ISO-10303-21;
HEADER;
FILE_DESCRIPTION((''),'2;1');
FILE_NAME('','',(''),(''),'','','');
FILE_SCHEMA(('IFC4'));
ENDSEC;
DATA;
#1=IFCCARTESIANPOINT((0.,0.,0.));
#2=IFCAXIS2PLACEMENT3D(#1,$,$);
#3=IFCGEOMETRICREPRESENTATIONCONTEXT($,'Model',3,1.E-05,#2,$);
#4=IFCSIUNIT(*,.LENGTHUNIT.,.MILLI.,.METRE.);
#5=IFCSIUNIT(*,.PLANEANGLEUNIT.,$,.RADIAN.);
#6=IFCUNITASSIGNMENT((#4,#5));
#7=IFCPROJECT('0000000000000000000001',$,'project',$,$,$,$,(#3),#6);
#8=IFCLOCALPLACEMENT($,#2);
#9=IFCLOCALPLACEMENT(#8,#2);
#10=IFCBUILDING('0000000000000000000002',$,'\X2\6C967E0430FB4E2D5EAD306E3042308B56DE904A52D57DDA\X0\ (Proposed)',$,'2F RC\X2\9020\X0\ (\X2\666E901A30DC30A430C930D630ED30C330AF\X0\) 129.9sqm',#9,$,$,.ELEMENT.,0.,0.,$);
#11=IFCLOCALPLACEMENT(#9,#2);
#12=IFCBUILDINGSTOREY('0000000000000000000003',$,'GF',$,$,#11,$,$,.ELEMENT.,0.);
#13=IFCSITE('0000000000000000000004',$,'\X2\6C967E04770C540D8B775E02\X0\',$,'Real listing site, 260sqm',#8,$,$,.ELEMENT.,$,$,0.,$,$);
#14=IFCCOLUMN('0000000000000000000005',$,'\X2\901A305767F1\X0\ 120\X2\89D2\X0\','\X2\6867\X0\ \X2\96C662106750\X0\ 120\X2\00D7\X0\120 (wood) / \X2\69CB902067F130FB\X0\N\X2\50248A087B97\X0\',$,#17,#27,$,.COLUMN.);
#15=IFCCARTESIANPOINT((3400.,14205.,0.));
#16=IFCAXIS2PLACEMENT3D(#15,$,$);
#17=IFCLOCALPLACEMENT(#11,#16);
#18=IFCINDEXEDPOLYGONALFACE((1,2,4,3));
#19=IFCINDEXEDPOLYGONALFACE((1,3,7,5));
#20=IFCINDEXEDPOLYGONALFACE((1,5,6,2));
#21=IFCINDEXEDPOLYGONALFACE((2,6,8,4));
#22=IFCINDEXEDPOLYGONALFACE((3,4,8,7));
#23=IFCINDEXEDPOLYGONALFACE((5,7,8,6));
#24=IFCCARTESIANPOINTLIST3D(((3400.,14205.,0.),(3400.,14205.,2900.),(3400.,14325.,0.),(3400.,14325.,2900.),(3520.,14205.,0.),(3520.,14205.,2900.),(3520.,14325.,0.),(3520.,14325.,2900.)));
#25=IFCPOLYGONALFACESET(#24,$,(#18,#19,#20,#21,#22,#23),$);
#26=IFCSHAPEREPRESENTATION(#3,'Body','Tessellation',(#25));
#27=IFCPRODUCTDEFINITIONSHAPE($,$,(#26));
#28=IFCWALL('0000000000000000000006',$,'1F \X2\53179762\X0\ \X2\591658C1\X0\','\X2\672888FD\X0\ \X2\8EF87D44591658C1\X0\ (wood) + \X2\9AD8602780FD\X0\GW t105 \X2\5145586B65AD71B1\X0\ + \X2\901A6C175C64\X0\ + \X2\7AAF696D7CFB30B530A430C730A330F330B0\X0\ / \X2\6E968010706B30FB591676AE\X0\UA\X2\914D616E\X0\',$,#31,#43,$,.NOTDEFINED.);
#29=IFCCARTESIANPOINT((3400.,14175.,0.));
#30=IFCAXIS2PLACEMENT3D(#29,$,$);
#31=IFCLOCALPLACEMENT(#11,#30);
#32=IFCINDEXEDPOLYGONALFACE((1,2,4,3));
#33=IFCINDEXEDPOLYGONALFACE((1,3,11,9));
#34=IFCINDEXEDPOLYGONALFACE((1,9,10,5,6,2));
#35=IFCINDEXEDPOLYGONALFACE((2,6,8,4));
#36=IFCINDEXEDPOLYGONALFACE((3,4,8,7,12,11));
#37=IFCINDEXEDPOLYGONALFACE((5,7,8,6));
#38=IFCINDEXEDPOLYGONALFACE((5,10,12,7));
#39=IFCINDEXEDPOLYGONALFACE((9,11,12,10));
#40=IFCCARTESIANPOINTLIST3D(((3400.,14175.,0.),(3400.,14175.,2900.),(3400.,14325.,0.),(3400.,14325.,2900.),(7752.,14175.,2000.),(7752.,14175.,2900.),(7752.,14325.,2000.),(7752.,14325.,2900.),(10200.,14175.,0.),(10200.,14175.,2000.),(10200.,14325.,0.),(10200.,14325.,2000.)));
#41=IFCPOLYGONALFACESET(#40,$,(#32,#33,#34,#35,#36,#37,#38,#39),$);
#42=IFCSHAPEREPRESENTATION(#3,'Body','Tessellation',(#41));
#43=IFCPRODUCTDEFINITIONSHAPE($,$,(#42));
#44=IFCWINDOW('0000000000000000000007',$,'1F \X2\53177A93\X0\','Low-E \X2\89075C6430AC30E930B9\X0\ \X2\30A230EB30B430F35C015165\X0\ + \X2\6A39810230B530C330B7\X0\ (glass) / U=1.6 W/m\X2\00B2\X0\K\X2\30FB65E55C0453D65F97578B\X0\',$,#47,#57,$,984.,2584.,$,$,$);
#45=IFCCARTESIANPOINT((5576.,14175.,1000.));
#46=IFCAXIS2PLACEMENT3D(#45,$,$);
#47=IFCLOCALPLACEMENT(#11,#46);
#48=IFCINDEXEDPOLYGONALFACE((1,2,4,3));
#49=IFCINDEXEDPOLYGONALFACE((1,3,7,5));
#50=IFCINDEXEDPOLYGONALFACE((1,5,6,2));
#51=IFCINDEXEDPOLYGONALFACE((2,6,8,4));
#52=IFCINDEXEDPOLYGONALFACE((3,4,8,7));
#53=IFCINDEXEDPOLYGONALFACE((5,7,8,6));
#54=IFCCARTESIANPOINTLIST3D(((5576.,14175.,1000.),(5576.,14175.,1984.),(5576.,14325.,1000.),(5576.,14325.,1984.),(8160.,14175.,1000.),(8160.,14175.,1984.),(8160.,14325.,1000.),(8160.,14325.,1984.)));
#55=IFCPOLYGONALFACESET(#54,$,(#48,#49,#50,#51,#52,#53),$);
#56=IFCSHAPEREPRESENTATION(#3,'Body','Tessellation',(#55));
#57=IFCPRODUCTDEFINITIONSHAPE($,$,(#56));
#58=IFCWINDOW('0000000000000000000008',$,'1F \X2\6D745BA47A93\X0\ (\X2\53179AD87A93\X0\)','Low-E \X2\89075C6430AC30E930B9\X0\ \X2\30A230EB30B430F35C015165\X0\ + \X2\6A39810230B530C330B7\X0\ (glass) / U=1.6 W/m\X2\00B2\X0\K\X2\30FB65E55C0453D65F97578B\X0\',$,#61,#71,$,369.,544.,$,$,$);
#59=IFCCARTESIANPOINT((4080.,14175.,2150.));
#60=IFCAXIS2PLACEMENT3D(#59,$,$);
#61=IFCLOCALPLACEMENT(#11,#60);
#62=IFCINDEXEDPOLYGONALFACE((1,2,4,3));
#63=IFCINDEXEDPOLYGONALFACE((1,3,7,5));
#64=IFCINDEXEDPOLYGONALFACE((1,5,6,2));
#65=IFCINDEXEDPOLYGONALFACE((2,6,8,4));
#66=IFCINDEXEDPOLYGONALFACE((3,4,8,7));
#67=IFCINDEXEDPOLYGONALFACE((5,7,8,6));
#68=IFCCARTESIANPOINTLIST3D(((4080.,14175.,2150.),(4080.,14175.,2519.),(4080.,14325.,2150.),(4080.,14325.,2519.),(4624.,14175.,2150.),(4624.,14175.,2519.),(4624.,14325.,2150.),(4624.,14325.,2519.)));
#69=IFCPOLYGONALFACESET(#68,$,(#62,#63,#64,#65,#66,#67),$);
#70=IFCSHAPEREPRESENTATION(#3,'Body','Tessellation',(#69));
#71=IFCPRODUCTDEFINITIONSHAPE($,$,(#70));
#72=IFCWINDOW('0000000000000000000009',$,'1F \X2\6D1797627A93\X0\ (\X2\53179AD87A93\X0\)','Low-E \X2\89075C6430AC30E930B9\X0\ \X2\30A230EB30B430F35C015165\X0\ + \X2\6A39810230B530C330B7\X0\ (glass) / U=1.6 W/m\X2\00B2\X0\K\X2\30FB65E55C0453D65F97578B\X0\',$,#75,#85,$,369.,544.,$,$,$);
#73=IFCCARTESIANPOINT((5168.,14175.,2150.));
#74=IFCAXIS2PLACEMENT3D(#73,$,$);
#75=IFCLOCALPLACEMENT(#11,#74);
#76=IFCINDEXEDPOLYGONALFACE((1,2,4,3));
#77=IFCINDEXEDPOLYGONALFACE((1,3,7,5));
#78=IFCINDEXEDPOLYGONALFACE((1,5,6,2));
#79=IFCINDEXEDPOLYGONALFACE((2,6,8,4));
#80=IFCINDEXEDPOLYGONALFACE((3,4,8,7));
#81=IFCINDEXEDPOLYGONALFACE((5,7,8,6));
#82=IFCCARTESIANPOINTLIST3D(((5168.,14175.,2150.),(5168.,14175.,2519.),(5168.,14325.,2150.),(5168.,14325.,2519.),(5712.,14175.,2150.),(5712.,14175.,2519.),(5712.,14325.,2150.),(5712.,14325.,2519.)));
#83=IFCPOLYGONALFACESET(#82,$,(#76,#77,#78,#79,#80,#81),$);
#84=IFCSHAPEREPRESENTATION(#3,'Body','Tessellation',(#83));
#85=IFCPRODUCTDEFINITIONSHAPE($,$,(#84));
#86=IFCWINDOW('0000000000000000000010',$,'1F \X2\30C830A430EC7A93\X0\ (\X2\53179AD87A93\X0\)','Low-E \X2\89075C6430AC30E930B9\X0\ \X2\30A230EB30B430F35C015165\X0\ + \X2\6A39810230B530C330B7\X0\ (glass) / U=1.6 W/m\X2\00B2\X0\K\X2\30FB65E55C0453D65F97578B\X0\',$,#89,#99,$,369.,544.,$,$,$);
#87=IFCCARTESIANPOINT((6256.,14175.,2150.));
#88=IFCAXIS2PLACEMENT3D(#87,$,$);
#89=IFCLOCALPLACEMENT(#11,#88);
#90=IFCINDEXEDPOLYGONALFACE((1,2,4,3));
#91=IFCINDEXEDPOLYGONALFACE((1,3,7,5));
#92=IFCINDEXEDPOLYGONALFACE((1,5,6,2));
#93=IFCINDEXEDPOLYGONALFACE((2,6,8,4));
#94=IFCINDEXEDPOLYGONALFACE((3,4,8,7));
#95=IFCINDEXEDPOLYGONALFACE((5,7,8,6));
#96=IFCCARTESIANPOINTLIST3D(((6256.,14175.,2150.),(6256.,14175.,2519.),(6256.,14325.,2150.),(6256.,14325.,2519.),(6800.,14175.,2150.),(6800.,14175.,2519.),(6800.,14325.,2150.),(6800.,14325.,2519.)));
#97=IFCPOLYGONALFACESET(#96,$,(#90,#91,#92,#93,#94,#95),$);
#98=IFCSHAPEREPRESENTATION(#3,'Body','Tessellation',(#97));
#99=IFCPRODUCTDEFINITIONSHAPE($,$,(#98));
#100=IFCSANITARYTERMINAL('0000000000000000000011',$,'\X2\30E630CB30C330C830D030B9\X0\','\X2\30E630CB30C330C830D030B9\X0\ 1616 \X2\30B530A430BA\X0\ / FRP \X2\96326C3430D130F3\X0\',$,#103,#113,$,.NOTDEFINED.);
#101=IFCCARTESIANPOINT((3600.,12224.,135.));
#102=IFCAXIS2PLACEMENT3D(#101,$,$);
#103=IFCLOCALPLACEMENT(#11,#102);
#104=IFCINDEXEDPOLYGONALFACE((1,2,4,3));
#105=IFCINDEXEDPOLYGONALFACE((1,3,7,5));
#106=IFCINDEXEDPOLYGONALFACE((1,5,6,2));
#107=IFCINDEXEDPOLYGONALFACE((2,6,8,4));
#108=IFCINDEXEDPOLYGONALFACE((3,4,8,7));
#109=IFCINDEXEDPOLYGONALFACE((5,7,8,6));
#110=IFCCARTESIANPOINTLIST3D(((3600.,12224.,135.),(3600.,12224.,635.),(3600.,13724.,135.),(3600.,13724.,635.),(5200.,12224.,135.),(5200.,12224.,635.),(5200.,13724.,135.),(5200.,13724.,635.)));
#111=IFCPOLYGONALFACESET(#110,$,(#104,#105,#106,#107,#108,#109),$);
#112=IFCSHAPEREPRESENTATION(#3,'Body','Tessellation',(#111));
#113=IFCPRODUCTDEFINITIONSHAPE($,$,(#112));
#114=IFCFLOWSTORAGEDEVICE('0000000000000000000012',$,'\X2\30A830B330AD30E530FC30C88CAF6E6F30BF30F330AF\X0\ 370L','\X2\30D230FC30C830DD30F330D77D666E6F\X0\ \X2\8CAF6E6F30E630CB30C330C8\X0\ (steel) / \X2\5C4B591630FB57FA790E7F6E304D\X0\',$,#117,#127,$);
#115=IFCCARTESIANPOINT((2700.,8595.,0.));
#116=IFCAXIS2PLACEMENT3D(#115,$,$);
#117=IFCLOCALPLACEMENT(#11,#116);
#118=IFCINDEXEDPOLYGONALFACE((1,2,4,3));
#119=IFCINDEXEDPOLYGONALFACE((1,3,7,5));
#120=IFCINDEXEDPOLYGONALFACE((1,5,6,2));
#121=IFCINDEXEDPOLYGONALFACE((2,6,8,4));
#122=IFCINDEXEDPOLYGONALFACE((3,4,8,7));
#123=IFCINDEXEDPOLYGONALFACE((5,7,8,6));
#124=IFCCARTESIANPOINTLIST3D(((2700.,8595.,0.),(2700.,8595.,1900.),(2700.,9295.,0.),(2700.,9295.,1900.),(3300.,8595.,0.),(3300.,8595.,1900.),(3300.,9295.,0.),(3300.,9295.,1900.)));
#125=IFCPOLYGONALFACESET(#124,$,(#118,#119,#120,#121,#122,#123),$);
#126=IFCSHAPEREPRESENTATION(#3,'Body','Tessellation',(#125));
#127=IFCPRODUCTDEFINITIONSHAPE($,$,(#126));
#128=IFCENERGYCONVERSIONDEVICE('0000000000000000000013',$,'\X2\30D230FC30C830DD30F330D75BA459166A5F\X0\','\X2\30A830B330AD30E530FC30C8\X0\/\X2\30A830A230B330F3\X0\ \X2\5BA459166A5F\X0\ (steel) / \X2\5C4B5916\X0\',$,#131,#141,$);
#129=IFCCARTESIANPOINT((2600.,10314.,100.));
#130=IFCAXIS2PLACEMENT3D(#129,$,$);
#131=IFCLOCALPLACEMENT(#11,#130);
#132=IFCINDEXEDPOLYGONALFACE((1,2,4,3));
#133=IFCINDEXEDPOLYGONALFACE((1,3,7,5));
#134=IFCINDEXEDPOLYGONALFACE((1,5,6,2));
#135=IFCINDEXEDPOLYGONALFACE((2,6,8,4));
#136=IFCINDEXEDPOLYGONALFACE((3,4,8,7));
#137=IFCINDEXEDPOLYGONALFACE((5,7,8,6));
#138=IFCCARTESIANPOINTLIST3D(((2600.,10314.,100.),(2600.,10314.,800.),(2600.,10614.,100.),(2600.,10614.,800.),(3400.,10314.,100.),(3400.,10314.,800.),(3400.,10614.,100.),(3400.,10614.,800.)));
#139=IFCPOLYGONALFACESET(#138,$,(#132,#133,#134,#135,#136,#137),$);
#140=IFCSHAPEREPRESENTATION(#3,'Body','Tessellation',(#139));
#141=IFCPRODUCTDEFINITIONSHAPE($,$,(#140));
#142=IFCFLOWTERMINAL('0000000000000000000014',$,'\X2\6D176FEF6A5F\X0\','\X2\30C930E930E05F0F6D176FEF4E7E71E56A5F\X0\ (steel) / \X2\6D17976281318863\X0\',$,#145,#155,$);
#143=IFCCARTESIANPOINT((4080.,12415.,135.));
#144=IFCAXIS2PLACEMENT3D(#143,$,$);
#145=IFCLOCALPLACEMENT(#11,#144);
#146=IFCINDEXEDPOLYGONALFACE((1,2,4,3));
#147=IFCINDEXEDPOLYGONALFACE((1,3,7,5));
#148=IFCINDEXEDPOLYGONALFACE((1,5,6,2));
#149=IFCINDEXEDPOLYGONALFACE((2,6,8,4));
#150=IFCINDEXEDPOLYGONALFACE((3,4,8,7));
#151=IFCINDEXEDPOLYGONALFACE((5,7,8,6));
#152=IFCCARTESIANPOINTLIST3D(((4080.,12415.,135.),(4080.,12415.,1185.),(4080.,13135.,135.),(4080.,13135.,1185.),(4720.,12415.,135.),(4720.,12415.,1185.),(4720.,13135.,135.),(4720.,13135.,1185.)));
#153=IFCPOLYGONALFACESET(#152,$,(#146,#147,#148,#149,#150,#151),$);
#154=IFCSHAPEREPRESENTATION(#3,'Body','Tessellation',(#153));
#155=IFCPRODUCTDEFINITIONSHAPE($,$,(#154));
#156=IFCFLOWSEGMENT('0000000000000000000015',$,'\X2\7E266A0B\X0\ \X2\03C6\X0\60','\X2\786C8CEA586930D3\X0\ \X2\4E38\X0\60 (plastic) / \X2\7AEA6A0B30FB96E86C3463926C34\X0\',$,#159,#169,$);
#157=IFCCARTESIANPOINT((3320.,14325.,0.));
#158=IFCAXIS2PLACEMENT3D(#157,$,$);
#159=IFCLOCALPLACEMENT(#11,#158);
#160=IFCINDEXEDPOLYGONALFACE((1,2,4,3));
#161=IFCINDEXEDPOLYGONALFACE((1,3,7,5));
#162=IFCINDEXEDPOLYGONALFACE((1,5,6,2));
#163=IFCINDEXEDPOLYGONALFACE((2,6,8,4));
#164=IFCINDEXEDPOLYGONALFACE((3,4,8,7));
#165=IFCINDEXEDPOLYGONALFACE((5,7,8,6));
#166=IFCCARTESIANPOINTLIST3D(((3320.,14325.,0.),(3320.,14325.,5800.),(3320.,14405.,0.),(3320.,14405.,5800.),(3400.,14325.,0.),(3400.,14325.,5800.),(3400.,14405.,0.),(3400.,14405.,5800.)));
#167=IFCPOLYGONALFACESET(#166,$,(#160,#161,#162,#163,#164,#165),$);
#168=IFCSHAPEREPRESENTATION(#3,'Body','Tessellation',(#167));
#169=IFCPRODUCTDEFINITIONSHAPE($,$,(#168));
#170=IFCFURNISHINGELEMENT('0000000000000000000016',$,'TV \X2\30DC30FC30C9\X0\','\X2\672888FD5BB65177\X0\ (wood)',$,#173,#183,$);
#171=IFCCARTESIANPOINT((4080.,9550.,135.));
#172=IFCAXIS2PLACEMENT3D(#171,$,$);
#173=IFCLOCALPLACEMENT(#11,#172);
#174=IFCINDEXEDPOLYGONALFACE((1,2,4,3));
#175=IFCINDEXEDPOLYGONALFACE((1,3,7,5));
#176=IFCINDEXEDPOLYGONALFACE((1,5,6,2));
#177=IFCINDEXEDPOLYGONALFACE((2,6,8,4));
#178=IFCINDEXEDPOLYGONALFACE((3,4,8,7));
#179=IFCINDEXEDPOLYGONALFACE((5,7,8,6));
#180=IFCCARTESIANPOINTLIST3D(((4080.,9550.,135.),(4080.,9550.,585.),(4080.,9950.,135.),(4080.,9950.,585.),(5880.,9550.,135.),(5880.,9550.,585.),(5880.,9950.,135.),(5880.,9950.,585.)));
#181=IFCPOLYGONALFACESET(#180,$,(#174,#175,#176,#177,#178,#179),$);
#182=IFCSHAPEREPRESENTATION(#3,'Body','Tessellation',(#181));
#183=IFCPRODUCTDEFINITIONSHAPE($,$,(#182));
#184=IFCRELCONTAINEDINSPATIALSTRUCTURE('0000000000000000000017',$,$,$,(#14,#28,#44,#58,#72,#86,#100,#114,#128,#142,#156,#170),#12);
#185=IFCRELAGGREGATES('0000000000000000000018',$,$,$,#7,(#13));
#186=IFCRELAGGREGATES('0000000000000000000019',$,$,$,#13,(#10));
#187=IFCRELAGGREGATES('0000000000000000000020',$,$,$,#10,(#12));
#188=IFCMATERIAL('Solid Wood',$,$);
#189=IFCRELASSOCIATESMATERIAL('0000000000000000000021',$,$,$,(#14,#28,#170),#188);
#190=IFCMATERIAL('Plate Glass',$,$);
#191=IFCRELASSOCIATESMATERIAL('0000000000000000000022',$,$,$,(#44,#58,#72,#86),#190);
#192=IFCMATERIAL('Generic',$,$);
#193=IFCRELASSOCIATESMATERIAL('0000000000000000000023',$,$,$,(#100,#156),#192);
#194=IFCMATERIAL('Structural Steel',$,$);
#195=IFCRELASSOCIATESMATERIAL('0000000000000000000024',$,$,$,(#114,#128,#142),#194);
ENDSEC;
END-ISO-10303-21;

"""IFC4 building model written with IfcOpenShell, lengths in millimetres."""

from ifc_helpers import new_model, si_unit, frame, frame_2d, origin, place, context, project, spatial, rectangle, extrude, material, element, fill, save


model = new_model("IFC4")

# Units and contexts
model_context = context("Model", 3, precision=1e-05, world=origin())
ifc_project = project(units=[si_unit("LENGTHUNIT", "METRE", prefix="MILLI"), si_unit("PLANEANGLEUNIT", "RADIAN")], contexts=[model_context])

# Site, building, storey
site_placement = place(None, origin())
site = spatial("IfcSite", under=ifc_project, at=site_placement, Name="沖縄県名護市", ObjectType="Real listing site, 260sqm", CompositionType="ELEMENT", RefElevation=0.0)
building_placement = place(site_placement, origin())
building = spatial("IfcBuilding", under=site, at=building_placement, Name="沖縄・中庭のある回遊動線 (Proposed)", ObjectType="2F RC造 (普通ボイドブロック) 129.9sqm", CompositionType="ELEMENT", ElevationOfRefHeight=0.0, ElevationOfTerrain=0.0)
storey_placement = place(building_placement, origin())
storey = spatial("IfcBuildingStorey", under=building, at=storey_placement, Name="GF", CompositionType="ELEMENT", Elevation=0.0)

# Column
ifc_material_1 = material(Name="Solid Wood")
column_1_placement = place(storey_placement, frame((3400.0, 14205.0, 0.0)))
element("IfcColumn", 1, at=column_1_placement, inside=storey, material=ifc_material_1, Name="通し柱 120角", Description="桧 集成材 120×120 (wood) / 構造柱・N値計算", PredefinedType="COLUMN", context=model_context, shape_type="SweptSolid", body=[
    extrude(rectangle(XDim=120.0, YDim=120.0, at=frame_2d((60.0, 60.0))), frame((3400.0, 14205.0, 0.0)), (0.0, 0.0, 1.0), 2900.0),
])

# Wall, openings, windows
wall_1_placement = place(storey_placement, frame((3400.0, 14175.0, 0.0)))
wall_1 = element("IfcWall", 2, at=wall_1_placement, inside=storey, material=ifc_material_1, Name="1F 北面 外壁", Description="木製 軸組外壁 (wood) + 高性能GW t105 充填断熱 + 通気層 + 窯業系サイディング / 準耐火・外皮UA配慮", PredefinedType="NOTDEFINED", context=model_context, shape_type="SweptSolid", body=[
    extrude(rectangle(XDim=6800.0, YDim=150.0, at=frame_2d((3400.0, 75.0))), frame((3400.0, 14175.0, 0.0)), (0.0, 0.0, 1.0), 2900.0),
])
opening_1_placement = place(storey_placement, frame((5576.0, 14175.0, 1000.0)))
opening_1 = element("IfcOpeningElement", 3, at=opening_1_placement, cuts=wall_1, PredefinedType="NOTDEFINED", context=model_context, shape_type="SweptSolid", body=[
    extrude(rectangle(XDim=2584.0, YDim=150.0, at=frame_2d((1292.0, 75.0))), frame((5576.0, 14175.0, 1000.0)), (0.0, 0.0, 1.0), 984.0),
])
opening_2_placement = place(storey_placement, frame((4080.0, 14175.0, 2150.0)))
opening_2 = element("IfcOpeningElement", 4, at=opening_2_placement, cuts=wall_1, PredefinedType="NOTDEFINED", context=model_context, shape_type="SweptSolid", body=[
    extrude(rectangle(XDim=544.0, YDim=150.0, at=frame_2d((272.0, 75.0))), frame((4080.0, 14175.0, 2150.0)), (0.0, 0.0, 1.0), 369.0),
])
opening_3_placement = place(storey_placement, frame((5168.0, 14175.0, 2150.0)))
opening_3 = element("IfcOpeningElement", 5, at=opening_3_placement, cuts=wall_1, PredefinedType="NOTDEFINED", context=model_context, shape_type="SweptSolid", body=[
    extrude(rectangle(XDim=544.0, YDim=150.0, at=frame_2d((272.0, 75.0))), frame((5168.0, 14175.0, 2150.0)), (0.0, 0.0, 1.0), 369.0),
])
opening_4_placement = place(storey_placement, frame((6256.0, 14175.0, 2150.0)))
opening_4 = element("IfcOpeningElement", 6, at=opening_4_placement, cuts=wall_1, PredefinedType="NOTDEFINED", context=model_context, shape_type="SweptSolid", body=[
    extrude(rectangle(XDim=544.0, YDim=150.0, at=frame_2d((272.0, 75.0))), frame((6256.0, 14175.0, 2150.0)), (0.0, 0.0, 1.0), 369.0),
])
ifc_material_2 = material(Name="Plate Glass")
window_1_placement = place(storey_placement, frame((5576.0, 14175.0, 1000.0)))
window_1 = element("IfcWindow", 7, at=window_1_placement, inside=storey, material=ifc_material_2, Name="1F 北窓", Description="Low-E 複層ガラス アルゴン封入 + 樹脂サッシ (glass) / U=1.6 W/m²K・日射取得型", OverallHeight=984.0, OverallWidth=2584.0, context=model_context, shape_type="SweptSolid", body=[
    extrude(rectangle(XDim=2584.0, YDim=150.0, at=frame_2d((1292.0, 75.0))), frame((5576.0, 14175.0, 1000.0)), (0.0, 0.0, 1.0), 984.0),
])
fill(opening_1, window_1)
window_2_placement = place(storey_placement, frame((4080.0, 14175.0, 2150.0)))
window_2 = element("IfcWindow", 8, at=window_2_placement, inside=storey, material=ifc_material_2, Name="1F 浴室窓 (北高窓)", Description="Low-E 複層ガラス アルゴン封入 + 樹脂サッシ (glass) / U=1.6 W/m²K・日射取得型", OverallHeight=369.0, OverallWidth=544.0, context=model_context, shape_type="SweptSolid", body=[
    extrude(rectangle(XDim=544.0, YDim=150.0, at=frame_2d((272.0, 75.0))), frame((4080.0, 14175.0, 2150.0)), (0.0, 0.0, 1.0), 369.0),
])
fill(opening_2, window_2)
window_3_placement = place(storey_placement, frame((5168.0, 14175.0, 2150.0)))
window_3 = element("IfcWindow", 9, at=window_3_placement, inside=storey, material=ifc_material_2, Name="1F 洗面窓 (北高窓)", Description="Low-E 複層ガラス アルゴン封入 + 樹脂サッシ (glass) / U=1.6 W/m²K・日射取得型", OverallHeight=369.0, OverallWidth=544.0, context=model_context, shape_type="SweptSolid", body=[
    extrude(rectangle(XDim=544.0, YDim=150.0, at=frame_2d((272.0, 75.0))), frame((5168.0, 14175.0, 2150.0)), (0.0, 0.0, 1.0), 369.0),
])
fill(opening_3, window_3)
window_4_placement = place(storey_placement, frame((6256.0, 14175.0, 2150.0)))
window_4 = element("IfcWindow", 10, at=window_4_placement, inside=storey, material=ifc_material_2, Name="1F トイレ窓 (北高窓)", Description="Low-E 複層ガラス アルゴン封入 + 樹脂サッシ (glass) / U=1.6 W/m²K・日射取得型", OverallHeight=369.0, OverallWidth=544.0, context=model_context, shape_type="SweptSolid", body=[
    extrude(rectangle(XDim=544.0, YDim=150.0, at=frame_2d((272.0, 75.0))), frame((6256.0, 14175.0, 2150.0)), (0.0, 0.0, 1.0), 369.0),
])
fill(opening_4, window_4)

# Sanitary terminal
ifc_material_3 = material(Name="Generic")
sanitary_terminal_placement = place(storey_placement, frame((3600.0, 12224.0, 135.0)))
element("IfcSanitaryTerminal", 11, at=sanitary_terminal_placement, inside=storey, material=ifc_material_3, Name="ユニットバス", Description="ユニットバス 1616 サイズ / FRP 防水パン", PredefinedType="NOTDEFINED", context=model_context, shape_type="SweptSolid", body=[
    extrude(rectangle(XDim=1600.0, YDim=1500.0, at=frame_2d((800.0, 750.0))), frame((3600.0, 12224.0, 135.0)), (0.0, 0.0, 1.0), 500.0),
])

# Flow storage device
ifc_material_4 = material(Name="Structural Steel")
flow_storage_device_placement = place(storey_placement, frame((2700.0, 8595.0, 0.0)))
element("IfcFlowStorageDevice", 12, at=flow_storage_device_placement, inside=storey, material=ifc_material_4, Name="エコキュート貯湯タンク 370L", Description="ヒートポンプ給湯 貯湯ユニット (steel) / 屋外・基礎置き", context=model_context, shape_type="SweptSolid", body=[
    extrude(rectangle(XDim=600.0, YDim=700.0, at=frame_2d((300.0, 350.0))), frame((2700.0, 8595.0, 0.0)), (0.0, 0.0, 1.0), 1900.0),
])

# Energy conversion device
energy_conversion_device_placement = place(storey_placement, frame((2600.0, 10314.0, 100.0)))
element("IfcEnergyConversionDevice", 13, at=energy_conversion_device_placement, inside=storey, material=ifc_material_4, Name="ヒートポンプ室外機", Description="エコキュート/エアコン 室外機 (steel) / 屋外", context=model_context, shape_type="SweptSolid", body=[
    extrude(rectangle(XDim=800.0, YDim=300.0, at=frame_2d((400.0, 150.0))), frame((2600.0, 10314.0, 100.0)), (0.0, 0.0, 1.0), 700.0),
])

# Flow terminal
flow_terminal_placement = place(storey_placement, frame((4080.0, 12415.0, 135.0)))
element("IfcFlowTerminal", 14, at=flow_terminal_placement, inside=storey, material=ifc_material_4, Name="洗濯機", Description="ドラム式洗濯乾燥機 (steel) / 洗面脱衣", context=model_context, shape_type="SweptSolid", body=[
    extrude(rectangle(XDim=640.0, YDim=720.0, at=frame_2d((320.0, 360.0))), frame((4080.0, 12415.0, 135.0)), (0.0, 0.0, 1.0), 1050.0),
])

# Flow segment
flow_segment_placement = place(storey_placement, frame((3320.0, 14325.0, 0.0)))
element("IfcFlowSegment", 15, at=flow_segment_placement, inside=storey, material=ifc_material_3, Name="縦樋 φ60", Description="硬質塩ビ 丸60 (plastic) / 竪樋・雨水排水", context=model_context, shape_type="SweptSolid", body=[
    extrude(rectangle(XDim=80.0, YDim=80.0, at=frame_2d((40.0, 40.0))), frame((3320.0, 14325.0, 0.0)), (0.0, 0.0, 1.0), 5800.0),
])

# Furnishing element
furnishing_placement = place(storey_placement, frame((4080.0, 9550.0, 135.0)))
element("IfcFurnishingElement", 16, at=furnishing_placement, inside=storey, material=ifc_material_1, Name="TV ボード", Description="木製家具 (wood)", context=model_context, shape_type="SweptSolid", body=[
    extrude(rectangle(XDim=1800.0, YDim=400.0, at=frame_2d((900.0, 200.0))), frame((4080.0, 9550.0, 135.0)), (0.0, 0.0, 1.0), 450.0),
])

save(model, "model.ifc")
